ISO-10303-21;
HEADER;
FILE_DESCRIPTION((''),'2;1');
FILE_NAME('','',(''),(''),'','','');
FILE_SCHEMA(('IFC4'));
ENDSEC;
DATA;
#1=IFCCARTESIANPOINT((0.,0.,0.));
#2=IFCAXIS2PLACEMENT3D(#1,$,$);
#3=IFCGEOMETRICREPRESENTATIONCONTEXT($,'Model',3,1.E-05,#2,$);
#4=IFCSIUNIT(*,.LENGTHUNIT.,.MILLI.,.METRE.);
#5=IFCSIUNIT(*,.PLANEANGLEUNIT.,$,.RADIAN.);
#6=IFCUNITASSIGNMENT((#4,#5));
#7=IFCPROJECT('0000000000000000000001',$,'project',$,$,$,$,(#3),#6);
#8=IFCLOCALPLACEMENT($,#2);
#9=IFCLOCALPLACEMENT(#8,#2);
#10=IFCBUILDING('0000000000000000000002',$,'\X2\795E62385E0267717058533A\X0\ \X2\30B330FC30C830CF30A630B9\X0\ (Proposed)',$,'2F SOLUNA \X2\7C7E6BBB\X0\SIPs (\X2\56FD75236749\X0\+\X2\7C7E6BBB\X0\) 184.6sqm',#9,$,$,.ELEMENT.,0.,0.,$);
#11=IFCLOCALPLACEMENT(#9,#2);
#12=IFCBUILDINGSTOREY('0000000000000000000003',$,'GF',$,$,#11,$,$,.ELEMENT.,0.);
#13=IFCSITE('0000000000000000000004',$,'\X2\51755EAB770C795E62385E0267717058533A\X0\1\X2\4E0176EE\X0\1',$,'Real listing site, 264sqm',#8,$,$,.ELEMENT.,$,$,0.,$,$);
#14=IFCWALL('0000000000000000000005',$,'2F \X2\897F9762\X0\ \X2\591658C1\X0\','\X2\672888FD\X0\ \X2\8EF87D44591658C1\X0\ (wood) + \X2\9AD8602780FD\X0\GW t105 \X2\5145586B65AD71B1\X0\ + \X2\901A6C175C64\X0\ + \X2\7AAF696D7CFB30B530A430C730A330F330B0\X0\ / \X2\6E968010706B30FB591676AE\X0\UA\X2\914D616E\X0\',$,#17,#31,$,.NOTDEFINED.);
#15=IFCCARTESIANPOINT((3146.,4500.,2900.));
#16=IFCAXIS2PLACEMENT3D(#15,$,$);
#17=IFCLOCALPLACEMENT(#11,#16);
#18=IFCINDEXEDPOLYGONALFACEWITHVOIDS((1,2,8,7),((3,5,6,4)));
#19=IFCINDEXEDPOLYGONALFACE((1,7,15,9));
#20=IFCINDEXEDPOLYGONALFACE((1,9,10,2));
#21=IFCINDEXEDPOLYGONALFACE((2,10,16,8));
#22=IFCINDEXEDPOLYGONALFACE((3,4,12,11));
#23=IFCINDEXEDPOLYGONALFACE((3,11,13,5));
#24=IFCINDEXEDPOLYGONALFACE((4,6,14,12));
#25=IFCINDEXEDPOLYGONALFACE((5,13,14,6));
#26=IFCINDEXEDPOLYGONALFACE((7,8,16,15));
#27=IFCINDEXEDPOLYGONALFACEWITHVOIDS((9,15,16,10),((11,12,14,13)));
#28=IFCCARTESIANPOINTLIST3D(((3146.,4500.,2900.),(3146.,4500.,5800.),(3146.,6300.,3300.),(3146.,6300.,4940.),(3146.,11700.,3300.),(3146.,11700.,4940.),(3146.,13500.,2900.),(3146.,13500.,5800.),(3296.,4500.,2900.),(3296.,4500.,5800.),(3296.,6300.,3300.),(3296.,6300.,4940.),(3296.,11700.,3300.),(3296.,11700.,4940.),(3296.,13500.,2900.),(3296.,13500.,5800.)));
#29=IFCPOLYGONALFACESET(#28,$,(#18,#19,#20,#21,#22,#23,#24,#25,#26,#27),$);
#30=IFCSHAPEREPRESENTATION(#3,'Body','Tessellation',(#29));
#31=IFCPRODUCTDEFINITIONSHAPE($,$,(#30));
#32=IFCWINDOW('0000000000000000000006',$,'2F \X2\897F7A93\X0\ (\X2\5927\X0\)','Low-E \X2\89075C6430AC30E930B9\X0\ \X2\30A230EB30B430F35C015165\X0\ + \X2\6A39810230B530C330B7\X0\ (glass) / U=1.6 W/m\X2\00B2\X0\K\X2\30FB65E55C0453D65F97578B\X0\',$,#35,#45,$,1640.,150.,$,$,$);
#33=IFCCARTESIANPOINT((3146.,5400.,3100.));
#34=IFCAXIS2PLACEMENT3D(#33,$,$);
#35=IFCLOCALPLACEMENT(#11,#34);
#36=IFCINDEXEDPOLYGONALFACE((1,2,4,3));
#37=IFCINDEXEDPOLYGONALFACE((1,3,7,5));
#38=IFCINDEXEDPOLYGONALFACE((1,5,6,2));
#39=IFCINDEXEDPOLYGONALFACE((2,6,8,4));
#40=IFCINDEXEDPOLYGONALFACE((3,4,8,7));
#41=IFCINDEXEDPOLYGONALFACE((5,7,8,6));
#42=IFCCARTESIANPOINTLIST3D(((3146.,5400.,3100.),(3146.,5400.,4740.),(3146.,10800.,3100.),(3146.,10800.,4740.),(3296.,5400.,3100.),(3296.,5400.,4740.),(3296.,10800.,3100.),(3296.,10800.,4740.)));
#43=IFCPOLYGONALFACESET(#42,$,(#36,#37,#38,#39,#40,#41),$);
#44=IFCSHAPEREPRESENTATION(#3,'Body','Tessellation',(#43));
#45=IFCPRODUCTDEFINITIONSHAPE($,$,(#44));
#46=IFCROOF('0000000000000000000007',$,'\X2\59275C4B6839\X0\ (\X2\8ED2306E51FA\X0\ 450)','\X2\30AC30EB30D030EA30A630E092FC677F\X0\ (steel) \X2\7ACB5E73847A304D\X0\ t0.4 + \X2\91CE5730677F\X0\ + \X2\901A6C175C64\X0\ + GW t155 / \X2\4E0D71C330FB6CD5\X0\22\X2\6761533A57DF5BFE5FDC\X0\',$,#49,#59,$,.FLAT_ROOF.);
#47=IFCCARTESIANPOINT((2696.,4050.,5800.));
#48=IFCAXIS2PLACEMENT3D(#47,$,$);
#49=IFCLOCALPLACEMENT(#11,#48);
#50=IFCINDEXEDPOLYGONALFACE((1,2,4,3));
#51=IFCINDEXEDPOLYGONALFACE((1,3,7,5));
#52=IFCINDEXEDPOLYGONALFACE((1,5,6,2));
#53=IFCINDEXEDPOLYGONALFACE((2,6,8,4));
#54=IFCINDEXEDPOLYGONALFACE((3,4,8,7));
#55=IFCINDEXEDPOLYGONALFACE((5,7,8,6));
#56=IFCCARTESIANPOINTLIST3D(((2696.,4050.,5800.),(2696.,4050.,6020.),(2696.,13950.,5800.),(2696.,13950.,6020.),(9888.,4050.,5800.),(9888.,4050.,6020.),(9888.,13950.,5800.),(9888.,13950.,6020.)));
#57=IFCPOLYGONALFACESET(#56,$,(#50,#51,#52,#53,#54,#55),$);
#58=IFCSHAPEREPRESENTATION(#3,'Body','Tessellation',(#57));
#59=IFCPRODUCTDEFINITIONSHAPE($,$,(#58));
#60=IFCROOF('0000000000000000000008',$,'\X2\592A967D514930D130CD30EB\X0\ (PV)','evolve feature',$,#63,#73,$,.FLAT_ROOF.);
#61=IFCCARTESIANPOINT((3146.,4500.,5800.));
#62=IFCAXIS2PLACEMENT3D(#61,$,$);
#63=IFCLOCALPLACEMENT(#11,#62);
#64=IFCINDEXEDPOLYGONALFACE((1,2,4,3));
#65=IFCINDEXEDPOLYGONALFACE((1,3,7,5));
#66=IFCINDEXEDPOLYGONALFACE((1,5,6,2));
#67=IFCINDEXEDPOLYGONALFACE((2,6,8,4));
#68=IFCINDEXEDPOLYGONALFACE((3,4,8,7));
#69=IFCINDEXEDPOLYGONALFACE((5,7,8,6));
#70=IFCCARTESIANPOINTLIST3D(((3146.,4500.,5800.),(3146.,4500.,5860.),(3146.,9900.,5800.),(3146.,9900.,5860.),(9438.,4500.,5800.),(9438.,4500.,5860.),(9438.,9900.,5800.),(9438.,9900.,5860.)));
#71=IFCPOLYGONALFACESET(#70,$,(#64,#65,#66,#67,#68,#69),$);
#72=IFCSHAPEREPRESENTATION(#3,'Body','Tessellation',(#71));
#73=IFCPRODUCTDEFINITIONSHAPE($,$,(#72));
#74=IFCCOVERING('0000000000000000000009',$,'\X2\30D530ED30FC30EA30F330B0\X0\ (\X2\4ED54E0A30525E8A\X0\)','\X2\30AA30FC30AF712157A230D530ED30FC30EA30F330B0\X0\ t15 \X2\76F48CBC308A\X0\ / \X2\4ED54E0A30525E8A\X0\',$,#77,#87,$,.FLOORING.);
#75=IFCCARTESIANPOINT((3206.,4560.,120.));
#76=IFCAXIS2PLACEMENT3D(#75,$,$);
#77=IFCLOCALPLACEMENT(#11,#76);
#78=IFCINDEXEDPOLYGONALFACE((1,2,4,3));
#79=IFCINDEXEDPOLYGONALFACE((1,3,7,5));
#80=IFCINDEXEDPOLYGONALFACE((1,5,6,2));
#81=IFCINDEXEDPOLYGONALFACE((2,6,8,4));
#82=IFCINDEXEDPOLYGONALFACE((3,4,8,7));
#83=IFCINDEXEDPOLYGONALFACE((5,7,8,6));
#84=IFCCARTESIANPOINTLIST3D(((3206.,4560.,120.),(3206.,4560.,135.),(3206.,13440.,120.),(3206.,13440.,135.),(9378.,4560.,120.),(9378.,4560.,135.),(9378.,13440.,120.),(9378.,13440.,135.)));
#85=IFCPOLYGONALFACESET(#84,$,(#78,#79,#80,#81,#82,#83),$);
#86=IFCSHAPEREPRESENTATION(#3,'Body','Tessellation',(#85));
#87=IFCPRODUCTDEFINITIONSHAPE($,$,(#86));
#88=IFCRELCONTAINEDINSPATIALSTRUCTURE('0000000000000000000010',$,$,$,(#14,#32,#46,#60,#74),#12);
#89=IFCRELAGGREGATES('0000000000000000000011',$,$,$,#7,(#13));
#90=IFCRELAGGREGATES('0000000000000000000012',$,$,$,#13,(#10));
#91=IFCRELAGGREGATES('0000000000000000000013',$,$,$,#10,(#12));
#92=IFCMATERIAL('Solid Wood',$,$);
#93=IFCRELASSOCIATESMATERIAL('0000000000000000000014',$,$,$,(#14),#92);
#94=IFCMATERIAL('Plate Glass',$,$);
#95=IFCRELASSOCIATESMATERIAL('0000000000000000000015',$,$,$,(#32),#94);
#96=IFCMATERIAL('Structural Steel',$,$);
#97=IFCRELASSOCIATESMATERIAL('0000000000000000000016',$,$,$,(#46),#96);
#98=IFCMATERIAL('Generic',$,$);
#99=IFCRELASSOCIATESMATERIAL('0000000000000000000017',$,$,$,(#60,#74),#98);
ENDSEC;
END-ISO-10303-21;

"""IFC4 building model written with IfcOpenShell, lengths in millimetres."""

from ifc_helpers import new_model, si_unit, frame, frame_2d, origin, place, context, project, spatial, rectangle, extrude, material, element, fill, save


model = new_model("IFC4")

# Units and contexts
model_context = context("Model", 3, precision=1e-05, world=origin())
ifc_project = project(units=[si_unit("LENGTHUNIT", "METRE", prefix="MILLI"), si_unit("PLANEANGLEUNIT", "RADIAN")], contexts=[model_context])

# Site, building, storey
site_placement = place(None, origin())
site = spatial("IfcSite", under=ifc_project, at=site_placement, Name="兵庫県神戸市東灘区1丁目1", ObjectType="Real listing site, 264sqm", CompositionType="ELEMENT", RefElevation=0.0)
building_placement = place(site_placement, origin())
building = spatial("IfcBuilding", under=site, at=building_placement, Name="神戸市東灘区 コートハウス (Proposed)", ObjectType="2F SOLUNA 籾殻SIPs (国産杉+籾殻) 184.6sqm", CompositionType="ELEMENT", ElevationOfRefHeight=0.0, ElevationOfTerrain=0.0)
storey_placement = place(building_placement, origin())
storey = spatial("IfcBuildingStorey", under=building, at=storey_placement, Name="GF", CompositionType="ELEMENT", Elevation=0.0)

# Shared definitions
ifc_material_1 = material(Name="Solid Wood")
ifc_material_2 = material(Name="Generic")

# Shared definitions
ifc_material_3 = material(Name="Plate Glass")

# Wall, opening, window
wall_1_placement = place(storey_placement, frame((3146.0, 4500.0, 2900.0)))
wall_1 = element("IfcWall", 1, at=wall_1_placement, inside=storey, material=ifc_material_1, Name="2F 西面 外壁", Description="木製 軸組外壁 (wood) + 高性能GW t105 充填断熱 + 通気層 + 窯業系サイディング / 準耐火・外皮UA配慮", PredefinedType="NOTDEFINED", context=model_context, shape_type="SweptSolid", body=[
    extrude(rectangle(XDim=150.0, YDim=9000.0, at=frame_2d((75.0, 4500.0))), frame((3146.0, 4500.0, 2900.0)), (0.0, 0.0, 1.0), 2900.0),
])
opening_1_placement = place(storey_placement, frame((3146.0, 5400.0, 3100.0)))
opening_1 = element("IfcOpeningElement", 2, at=opening_1_placement, cuts=wall_1, PredefinedType="NOTDEFINED", context=model_context, shape_type="SweptSolid", body=[
    extrude(rectangle(XDim=150.0, YDim=5400.0, at=frame_2d((75.0, 2700.0))), frame((3146.0, 5400.0, 3100.0)), (0.0, 0.0, 1.0), 1640.0),
])
window_1_placement = place(storey_placement, frame((3146.0, 5400.0, 3100.0)))
window_1 = element("IfcWindow", 3, at=window_1_placement, inside=storey, material=ifc_material_3, Name="2F 西窓 (大)", Description="Low-E 複層ガラス アルゴン封入 + 樹脂サッシ (glass) / U=1.6 W/m²K・日射取得型", OverallHeight=1640.0, OverallWidth=150.0, context=model_context, shape_type="SweptSolid", body=[
    extrude(rectangle(XDim=150.0, YDim=5400.0, at=frame_2d((75.0, 2700.0))), frame((3146.0, 5400.0, 3100.0)), (0.0, 0.0, 1.0), 1640.0),
])
fill(opening_1, window_1)

# Roofs
ifc_material_4 = material(Name="Structural Steel")
roof_1_placement = place(storey_placement, frame((2696.0, 4050.0, 5800.0)))
element("IfcRoof", 4, at=roof_1_placement, inside=storey, material=ifc_material_4, Name="大屋根 (軒の出 450)", Description="ガルバリウム鋼板 (steel) 立平葺き t0.4 + 野地板 + 通気層 + GW t155 / 不燃・法22条区域対応", PredefinedType="FLAT_ROOF", context=model_context, shape_type="SweptSolid", body=[
    extrude(rectangle(XDim=7192.0, YDim=9900.0, at=frame_2d((3596.0, 4950.0))), frame((2696.0, 4050.0, 5800.0)), (0.0, 0.0, 1.0), 220.0),
])
roof_2_placement = place(storey_placement, frame((3146.0, 4500.0, 5800.0)))
element("IfcRoof", 5, at=roof_2_placement, inside=storey, material=ifc_material_2, Name="太陽光パネル (PV)", Description="evolve feature", PredefinedType="FLAT_ROOF", context=model_context, shape_type="SweptSolid", body=[
    extrude(rectangle(XDim=6292.0, YDim=5400.0, at=frame_2d((3146.0, 2700.0))), frame((3146.0, 4500.0, 5800.0)), (0.0, 0.0, 1.0), 60.0),
])

# Covering
covering_placement = place(storey_placement, frame((3206.0, 4560.0, 120.0)))
element("IfcCovering", 6, at=covering_placement, inside=storey, material=ifc_material_2, Name="フローリング (仕上げ床)", Description="オーク無垢フローリング t15 直貼り / 仕上げ床", PredefinedType="FLOORING", context=model_context, shape_type="SweptSolid", body=[
    extrude(rectangle(XDim=6172.0, YDim=8880.0, at=frame_2d((3086.0, 4440.0))), frame((3206.0, 4560.0, 120.0)), (0.0, 0.0, 1.0), 15.0),
])

save(model, "model.ifc")
